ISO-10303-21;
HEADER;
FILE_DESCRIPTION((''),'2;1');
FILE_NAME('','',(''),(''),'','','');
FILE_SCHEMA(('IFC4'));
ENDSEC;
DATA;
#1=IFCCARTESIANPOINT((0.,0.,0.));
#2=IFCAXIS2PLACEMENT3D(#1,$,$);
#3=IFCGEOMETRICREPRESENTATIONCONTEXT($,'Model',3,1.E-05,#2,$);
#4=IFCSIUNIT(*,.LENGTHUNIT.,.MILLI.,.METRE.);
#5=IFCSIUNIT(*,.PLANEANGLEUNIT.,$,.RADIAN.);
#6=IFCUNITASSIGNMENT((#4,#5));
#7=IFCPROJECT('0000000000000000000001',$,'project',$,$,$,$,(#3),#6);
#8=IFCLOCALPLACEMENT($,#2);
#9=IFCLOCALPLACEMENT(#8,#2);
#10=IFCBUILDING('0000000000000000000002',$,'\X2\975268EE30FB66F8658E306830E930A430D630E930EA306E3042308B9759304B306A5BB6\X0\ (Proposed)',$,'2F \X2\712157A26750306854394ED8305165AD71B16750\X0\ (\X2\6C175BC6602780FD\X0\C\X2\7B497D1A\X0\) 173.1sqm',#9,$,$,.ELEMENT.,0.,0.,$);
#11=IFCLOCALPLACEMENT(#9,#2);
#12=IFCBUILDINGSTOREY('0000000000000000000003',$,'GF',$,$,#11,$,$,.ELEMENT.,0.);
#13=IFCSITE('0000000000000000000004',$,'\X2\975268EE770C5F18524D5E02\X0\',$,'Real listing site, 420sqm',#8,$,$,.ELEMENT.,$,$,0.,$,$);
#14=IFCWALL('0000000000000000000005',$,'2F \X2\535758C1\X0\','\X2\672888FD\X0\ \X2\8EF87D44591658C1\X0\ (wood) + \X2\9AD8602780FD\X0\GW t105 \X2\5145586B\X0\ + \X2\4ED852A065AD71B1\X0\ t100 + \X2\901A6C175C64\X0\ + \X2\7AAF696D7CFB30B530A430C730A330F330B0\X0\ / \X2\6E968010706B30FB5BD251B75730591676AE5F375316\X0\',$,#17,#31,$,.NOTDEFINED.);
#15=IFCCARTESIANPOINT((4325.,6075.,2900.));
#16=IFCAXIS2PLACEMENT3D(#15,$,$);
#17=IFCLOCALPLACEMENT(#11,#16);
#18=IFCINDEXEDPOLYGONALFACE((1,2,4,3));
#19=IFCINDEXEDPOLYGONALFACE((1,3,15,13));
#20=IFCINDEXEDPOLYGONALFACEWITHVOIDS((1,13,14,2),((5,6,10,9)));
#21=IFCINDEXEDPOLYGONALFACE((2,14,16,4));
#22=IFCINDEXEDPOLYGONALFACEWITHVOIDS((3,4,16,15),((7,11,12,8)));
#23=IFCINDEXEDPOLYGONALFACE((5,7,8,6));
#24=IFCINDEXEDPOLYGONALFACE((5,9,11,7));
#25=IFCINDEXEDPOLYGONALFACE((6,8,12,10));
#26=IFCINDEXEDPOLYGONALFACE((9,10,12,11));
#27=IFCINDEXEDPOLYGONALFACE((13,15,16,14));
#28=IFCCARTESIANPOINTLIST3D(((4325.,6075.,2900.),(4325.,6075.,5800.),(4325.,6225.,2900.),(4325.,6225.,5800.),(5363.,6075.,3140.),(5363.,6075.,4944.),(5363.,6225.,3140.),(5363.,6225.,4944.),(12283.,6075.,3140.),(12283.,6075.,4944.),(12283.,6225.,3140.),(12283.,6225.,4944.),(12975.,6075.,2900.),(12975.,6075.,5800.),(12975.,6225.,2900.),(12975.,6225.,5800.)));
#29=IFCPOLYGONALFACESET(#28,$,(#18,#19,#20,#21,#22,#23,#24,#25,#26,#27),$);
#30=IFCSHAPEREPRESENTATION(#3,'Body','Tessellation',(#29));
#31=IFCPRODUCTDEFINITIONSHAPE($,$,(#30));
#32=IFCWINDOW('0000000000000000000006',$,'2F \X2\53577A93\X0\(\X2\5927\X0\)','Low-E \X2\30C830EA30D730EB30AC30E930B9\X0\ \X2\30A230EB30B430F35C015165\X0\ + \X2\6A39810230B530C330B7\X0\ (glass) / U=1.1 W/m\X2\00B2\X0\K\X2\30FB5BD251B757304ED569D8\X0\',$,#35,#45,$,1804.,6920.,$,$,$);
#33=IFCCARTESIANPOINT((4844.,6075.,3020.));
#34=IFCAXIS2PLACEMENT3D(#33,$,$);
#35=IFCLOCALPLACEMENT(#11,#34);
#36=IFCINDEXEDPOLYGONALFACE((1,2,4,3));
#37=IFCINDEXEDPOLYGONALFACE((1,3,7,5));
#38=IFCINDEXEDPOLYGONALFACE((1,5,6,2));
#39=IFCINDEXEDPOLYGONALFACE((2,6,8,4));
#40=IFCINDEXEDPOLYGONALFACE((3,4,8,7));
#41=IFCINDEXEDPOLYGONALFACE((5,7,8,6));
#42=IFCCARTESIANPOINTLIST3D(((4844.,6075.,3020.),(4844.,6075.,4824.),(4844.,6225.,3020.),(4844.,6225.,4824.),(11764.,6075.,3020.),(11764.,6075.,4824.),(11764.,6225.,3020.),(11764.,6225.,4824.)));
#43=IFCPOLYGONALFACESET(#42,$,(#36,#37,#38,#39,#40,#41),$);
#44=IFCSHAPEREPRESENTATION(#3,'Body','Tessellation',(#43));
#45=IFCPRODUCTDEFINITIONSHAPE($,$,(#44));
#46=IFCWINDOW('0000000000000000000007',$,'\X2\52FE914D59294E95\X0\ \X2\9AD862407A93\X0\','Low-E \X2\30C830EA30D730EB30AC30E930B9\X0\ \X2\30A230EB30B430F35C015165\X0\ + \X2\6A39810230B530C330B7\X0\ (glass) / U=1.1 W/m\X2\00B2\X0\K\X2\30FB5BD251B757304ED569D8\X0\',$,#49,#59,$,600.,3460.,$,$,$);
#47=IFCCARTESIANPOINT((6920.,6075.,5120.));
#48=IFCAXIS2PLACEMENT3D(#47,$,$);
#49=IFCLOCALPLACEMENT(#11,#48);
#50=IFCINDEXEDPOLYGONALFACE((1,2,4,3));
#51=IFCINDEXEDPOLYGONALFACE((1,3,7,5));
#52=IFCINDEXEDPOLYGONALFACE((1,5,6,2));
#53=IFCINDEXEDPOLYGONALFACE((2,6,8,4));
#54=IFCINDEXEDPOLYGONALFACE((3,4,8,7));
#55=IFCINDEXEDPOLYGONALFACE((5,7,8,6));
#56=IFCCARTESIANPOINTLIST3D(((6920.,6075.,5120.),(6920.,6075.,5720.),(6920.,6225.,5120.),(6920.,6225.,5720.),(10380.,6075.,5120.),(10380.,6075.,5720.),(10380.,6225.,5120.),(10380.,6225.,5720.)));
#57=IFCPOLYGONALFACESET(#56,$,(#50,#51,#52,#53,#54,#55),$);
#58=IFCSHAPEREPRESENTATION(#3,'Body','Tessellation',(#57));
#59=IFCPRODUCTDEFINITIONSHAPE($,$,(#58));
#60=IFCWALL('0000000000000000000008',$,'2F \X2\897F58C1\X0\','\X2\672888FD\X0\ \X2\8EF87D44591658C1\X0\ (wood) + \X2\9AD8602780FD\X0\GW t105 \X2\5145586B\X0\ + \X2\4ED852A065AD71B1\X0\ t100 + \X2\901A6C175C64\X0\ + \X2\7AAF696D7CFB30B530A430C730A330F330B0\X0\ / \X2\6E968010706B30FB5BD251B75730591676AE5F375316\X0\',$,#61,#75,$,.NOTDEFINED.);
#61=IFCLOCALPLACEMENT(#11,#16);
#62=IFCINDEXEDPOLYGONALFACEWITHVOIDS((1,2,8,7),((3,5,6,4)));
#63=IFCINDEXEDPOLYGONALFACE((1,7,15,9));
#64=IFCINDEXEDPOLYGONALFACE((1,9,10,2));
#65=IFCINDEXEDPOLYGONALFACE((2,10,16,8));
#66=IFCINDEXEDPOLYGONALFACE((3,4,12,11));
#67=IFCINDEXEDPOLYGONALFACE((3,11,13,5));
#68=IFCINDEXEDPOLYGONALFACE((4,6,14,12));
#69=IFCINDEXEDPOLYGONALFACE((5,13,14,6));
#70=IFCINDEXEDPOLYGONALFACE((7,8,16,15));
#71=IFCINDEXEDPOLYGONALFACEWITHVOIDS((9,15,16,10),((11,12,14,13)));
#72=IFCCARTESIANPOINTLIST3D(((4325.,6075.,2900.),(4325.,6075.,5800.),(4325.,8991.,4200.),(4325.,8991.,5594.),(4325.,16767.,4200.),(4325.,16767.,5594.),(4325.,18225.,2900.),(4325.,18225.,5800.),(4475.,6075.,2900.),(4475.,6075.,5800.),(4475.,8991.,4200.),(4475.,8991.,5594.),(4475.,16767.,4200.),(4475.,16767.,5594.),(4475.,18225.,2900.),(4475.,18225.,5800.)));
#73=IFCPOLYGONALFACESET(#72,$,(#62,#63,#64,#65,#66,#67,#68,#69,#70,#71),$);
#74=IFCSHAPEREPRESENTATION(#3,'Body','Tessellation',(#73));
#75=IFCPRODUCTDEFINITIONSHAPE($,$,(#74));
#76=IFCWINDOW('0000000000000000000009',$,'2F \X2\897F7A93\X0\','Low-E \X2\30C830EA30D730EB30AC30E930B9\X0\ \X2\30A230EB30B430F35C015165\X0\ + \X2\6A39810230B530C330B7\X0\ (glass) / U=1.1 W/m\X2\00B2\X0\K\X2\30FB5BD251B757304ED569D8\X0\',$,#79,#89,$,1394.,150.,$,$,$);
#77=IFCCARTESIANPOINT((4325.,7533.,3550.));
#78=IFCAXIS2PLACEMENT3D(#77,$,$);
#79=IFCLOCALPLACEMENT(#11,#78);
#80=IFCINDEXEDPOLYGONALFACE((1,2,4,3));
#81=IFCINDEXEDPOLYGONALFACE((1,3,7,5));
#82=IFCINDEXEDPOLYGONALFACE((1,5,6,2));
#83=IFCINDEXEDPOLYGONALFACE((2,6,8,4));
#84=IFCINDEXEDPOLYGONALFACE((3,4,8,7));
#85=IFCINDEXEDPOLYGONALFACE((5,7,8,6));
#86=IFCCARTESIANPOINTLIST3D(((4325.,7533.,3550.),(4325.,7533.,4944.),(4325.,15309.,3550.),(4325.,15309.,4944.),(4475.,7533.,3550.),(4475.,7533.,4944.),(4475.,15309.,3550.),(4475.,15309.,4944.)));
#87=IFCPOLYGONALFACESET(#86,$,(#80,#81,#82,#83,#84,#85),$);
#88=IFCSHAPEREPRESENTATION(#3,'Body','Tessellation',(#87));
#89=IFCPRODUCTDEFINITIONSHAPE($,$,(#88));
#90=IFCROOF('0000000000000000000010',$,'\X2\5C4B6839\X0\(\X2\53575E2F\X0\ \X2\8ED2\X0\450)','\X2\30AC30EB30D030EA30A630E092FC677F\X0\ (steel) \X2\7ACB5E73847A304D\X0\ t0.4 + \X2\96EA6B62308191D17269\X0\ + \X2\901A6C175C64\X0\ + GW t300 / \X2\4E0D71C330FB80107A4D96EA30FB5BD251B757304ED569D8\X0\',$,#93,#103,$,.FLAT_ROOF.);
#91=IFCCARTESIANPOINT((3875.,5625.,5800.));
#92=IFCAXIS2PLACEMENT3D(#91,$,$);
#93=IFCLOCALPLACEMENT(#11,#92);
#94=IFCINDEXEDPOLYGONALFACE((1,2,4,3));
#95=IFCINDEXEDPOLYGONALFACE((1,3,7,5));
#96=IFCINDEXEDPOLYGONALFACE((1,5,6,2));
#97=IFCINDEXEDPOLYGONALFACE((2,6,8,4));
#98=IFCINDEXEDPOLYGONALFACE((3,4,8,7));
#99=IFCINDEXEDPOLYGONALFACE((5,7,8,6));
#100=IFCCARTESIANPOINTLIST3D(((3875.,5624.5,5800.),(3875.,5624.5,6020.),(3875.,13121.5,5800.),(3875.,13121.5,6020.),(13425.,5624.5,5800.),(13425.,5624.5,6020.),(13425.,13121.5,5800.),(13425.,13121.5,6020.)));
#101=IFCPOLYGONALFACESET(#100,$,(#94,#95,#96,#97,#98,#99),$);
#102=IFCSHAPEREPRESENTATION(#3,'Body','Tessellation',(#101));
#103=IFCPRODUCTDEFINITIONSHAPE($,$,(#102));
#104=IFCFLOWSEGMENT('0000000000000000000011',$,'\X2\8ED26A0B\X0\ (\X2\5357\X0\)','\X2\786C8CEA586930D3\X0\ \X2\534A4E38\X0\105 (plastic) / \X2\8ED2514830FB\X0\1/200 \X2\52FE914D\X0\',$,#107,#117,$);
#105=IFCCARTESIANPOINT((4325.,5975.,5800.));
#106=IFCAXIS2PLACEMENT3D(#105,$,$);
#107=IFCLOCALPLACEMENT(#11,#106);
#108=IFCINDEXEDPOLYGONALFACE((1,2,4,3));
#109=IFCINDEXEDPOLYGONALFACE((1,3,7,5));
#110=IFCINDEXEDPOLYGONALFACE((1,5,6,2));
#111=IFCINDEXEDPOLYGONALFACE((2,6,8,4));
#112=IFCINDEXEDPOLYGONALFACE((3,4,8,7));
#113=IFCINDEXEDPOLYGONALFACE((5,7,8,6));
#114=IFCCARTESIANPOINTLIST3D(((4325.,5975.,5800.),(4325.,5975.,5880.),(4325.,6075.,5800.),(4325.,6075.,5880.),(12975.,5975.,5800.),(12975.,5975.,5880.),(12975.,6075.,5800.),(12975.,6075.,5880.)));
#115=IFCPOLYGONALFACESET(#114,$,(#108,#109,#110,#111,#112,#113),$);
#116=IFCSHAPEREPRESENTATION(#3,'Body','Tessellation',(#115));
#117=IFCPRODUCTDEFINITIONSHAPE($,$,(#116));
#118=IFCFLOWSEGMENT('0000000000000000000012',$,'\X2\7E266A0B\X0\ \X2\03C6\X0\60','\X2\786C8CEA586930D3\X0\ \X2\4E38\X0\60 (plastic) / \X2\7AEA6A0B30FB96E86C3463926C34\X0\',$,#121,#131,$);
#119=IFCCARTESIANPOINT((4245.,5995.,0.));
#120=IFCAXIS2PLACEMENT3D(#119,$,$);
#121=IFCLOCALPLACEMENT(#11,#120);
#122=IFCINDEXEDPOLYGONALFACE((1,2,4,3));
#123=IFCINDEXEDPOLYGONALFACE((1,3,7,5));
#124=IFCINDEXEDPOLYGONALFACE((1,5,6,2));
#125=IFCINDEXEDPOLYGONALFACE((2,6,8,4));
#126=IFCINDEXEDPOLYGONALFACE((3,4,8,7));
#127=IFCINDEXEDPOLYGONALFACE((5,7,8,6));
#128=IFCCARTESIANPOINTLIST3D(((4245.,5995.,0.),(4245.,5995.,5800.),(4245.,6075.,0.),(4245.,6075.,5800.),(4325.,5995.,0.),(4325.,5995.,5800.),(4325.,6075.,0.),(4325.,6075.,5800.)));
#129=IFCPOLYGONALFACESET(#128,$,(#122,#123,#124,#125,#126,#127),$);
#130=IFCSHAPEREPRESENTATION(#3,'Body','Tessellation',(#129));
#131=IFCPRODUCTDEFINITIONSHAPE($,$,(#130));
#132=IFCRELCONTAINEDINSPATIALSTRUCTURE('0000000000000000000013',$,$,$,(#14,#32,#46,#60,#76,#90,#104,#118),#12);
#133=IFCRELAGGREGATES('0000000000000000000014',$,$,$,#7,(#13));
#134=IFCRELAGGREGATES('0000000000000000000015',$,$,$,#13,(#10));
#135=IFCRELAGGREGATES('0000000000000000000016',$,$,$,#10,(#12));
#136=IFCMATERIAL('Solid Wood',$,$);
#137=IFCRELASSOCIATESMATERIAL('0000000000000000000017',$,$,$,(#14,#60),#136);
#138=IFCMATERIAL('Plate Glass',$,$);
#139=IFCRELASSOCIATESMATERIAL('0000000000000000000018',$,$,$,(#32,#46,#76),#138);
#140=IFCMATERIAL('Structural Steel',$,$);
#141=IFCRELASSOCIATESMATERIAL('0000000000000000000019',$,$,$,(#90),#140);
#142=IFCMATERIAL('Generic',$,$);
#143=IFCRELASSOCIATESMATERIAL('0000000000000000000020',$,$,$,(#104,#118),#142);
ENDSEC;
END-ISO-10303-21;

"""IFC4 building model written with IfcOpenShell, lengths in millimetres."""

from ifc_helpers import new_model, si_unit, frame, frame_2d, origin, place, context, project, spatial, rectangle, extrude, material, element, fill, save


model = new_model("IFC4")

# Units and contexts
model_context = context("Model", 3, precision=1e-05, world=origin())
ifc_project = project(units=[si_unit("LENGTHUNIT", "METRE", prefix="MILLI"), si_unit("PLANEANGLEUNIT", "RADIAN")], contexts=[model_context])

# Site, building, storey
site_placement = place(None, origin())
site = spatial("IfcSite", under=ifc_project, at=site_placement, Name="青森県弘前市", ObjectType="Real listing site, 420sqm", CompositionType="ELEMENT", RefElevation=0.0)
building_placement = place(site_placement, origin())
building = spatial("IfcBuilding", under=site, at=building_placement, Name="青森・書斎とライブラリのある静かな家 (Proposed)", ObjectType="2F 無垢材と吹付け断熱材 (気密性能C等級) 173.1sqm", CompositionType="ELEMENT", ElevationOfRefHeight=0.0, ElevationOfTerrain=0.0)
storey_placement = place(building_placement, origin())
storey = spatial("IfcBuildingStorey", under=building, at=storey_placement, Name="GF", CompositionType="ELEMENT", Elevation=0.0)

# Shared definitions
ifc_material_1 = material(Name="Solid Wood")

# Shared definitions
ifc_material_2 = material(Name="Plate Glass")

# Wall, openings, windows
wall_1_placement = place(storey_placement, frame((4325.0, 6075.0, 2900.0)))
wall_1 = element("IfcWall", 1, at=wall_1_placement, inside=storey, material=ifc_material_1, Name="2F 南壁", Description="木製 軸組外壁 (wood) + 高性能GW t105 充填 + 付加断熱 t100 + 通気層 + 窯業系サイディング / 準耐火・寒冷地外皮強化", PredefinedType="NOTDEFINED", context=model_context, shape_type="SweptSolid", body=[
    extrude(rectangle(XDim=8650.0, YDim=150.0, at=frame_2d((4325.0, 75.0))), frame((4325.0, 6075.0, 2900.0)), (0.0, 0.0, 1.0), 2900.0),
])
opening_1_placement = place(storey_placement, frame((4844.0, 6075.0, 3020.0)))
opening_1 = element("IfcOpeningElement", 2, at=opening_1_placement, cuts=wall_1, PredefinedType="NOTDEFINED", context=model_context, shape_type="SweptSolid", body=[
    extrude(rectangle(XDim=6920.0, YDim=150.0, at=frame_2d((3460.0, 75.0))), frame((4844.0, 6075.0, 3020.0)), (0.0, 0.0, 1.0), 1804.0),
])
opening_2_placement = place(storey_placement, frame((6920.0, 6075.0, 5120.0)))
opening_2 = element("IfcOpeningElement", 3, at=opening_2_placement, cuts=wall_1, PredefinedType="NOTDEFINED", context=model_context, shape_type="SweptSolid", body=[
    extrude(rectangle(XDim=3460.0, YDim=150.0, at=frame_2d((1730.0, 75.0))), frame((6920.0, 6075.0, 5120.0)), (0.0, 0.0, 1.0), 600.0),
])
window_1_placement = place(storey_placement, frame((4844.0, 6075.0, 3020.0)))
window_1 = element("IfcWindow", 4, at=window_1_placement, inside=storey, material=ifc_material_2, Name="2F 南窓(大)", Description="Low-E トリプルガラス アルゴン封入 + 樹脂サッシ (glass) / U=1.1 W/m²K・寒冷地仕様", OverallHeight=1804.0, OverallWidth=6920.0, context=model_context, shape_type="SweptSolid", body=[
    extrude(rectangle(XDim=6920.0, YDim=150.0, at=frame_2d((3460.0, 75.0))), frame((4844.0, 6075.0, 3020.0)), (0.0, 0.0, 1.0), 1804.0),
])
fill(opening_1, window_1)
window_2_placement = place(storey_placement, frame((6920.0, 6075.0, 5120.0)))
window_2 = element("IfcWindow", 5, at=window_2_placement, inside=storey, material=ifc_material_2, Name="勾配天井 高所窓", Description="Low-E トリプルガラス アルゴン封入 + 樹脂サッシ (glass) / U=1.1 W/m²K・寒冷地仕様", OverallHeight=600.0, OverallWidth=3460.0, context=model_context, shape_type="SweptSolid", body=[
    extrude(rectangle(XDim=3460.0, YDim=150.0, at=frame_2d((1730.0, 75.0))), frame((6920.0, 6075.0, 5120.0)), (0.0, 0.0, 1.0), 600.0),
])
fill(opening_2, window_2)

# Wall, opening, window
wall_2_placement = place(storey_placement, frame((4325.0, 6075.0, 2900.0)))
wall_2 = element("IfcWall", 6, at=wall_2_placement, inside=storey, material=ifc_material_1, Name="2F 西壁", Description="木製 軸組外壁 (wood) + 高性能GW t105 充填 + 付加断熱 t100 + 通気層 + 窯業系サイディング / 準耐火・寒冷地外皮強化", PredefinedType="NOTDEFINED", context=model_context, shape_type="SweptSolid", body=[
    extrude(rectangle(XDim=150.0, YDim=12150.0, at=frame_2d((75.0, 6075.0))), frame((4325.0, 6075.0, 2900.0)), (0.0, 0.0, 1.0), 2900.0),
])
opening_3_placement = place(storey_placement, frame((4325.0, 7533.0, 3550.0)))
opening_3 = element("IfcOpeningElement", 7, at=opening_3_placement, cuts=wall_2, PredefinedType="NOTDEFINED", context=model_context, shape_type="SweptSolid", body=[
    extrude(rectangle(XDim=150.0, YDim=7776.0, at=frame_2d((75.0, 3888.0))), frame((4325.0, 7533.0, 3550.0)), (0.0, 0.0, 1.0), 1394.0),
])
window_3_placement = place(storey_placement, frame((4325.0, 7533.0, 3550.0)))
window_3 = element("IfcWindow", 8, at=window_3_placement, inside=storey, material=ifc_material_2, Name="2F 西窓", Description="Low-E トリプルガラス アルゴン封入 + 樹脂サッシ (glass) / U=1.1 W/m²K・寒冷地仕様", OverallHeight=1394.0, OverallWidth=150.0, context=model_context, shape_type="SweptSolid", body=[
    extrude(rectangle(XDim=150.0, YDim=7776.0, at=frame_2d((75.0, 3888.0))), frame((4325.0, 7533.0, 3550.0)), (0.0, 0.0, 1.0), 1394.0),
])
fill(opening_3, window_3)

# Roof
ifc_material_3 = material(Name="Structural Steel")
for number, where, name in (
    (9, (3875.0, 5625.0, 5800.0), "屋根(南帯 軒450)"),
):
    element("IfcRoof", number, at=place(storey_placement, frame(where)), inside=storey, material=ifc_material_3, Name=name, Description="ガルバリウム鋼板 (steel) 立平葺き t0.4 + 雪止め金物 + 通気層 + GW t300 / 不燃・耐積雪・寒冷地仕様", PredefinedType="FLAT_ROOF", context=model_context, shape_type="SweptSolid", body=[
        extrude(rectangle(XDim=9550.0, YDim=7497.0, at=frame_2d((4775.0, 3748.0))), frame((3875.0, 5625.0, 5800.0)), (0.0, 0.0, 1.0), 220.0),
    ])

# Flow segments
ifc_material_4 = material(Name="Generic")
flow_segment_1_placement = place(storey_placement, frame((4325.0, 5975.0, 5800.0)))
element("IfcFlowSegment", 10, at=flow_segment_1_placement, inside=storey, material=ifc_material_4, Name="軒樋 (南)", Description="硬質塩ビ 半丸105 (plastic) / 軒先・1/200 勾配", context=model_context, shape_type="SweptSolid", body=[
    extrude(rectangle(XDim=8650.0, YDim=100.0, at=frame_2d((4325.0, 50.0))), frame((4325.0, 5975.0, 5800.0)), (0.0, 0.0, 1.0), 80.0),
])
flow_segment_2_placement = place(storey_placement, frame((4245.0, 5995.0, 0.0)))
element("IfcFlowSegment", 11, at=flow_segment_2_placement, inside=storey, material=ifc_material_4, Name="縦樋 φ60", Description="硬質塩ビ 丸60 (plastic) / 竪樋・雨水排水", context=model_context, shape_type="SweptSolid", body=[
    extrude(rectangle(XDim=80.0, YDim=80.0, at=frame_2d((40.0, 40.0))), frame((4245.0, 5995.0, 0.0)), (0.0, 0.0, 1.0), 5800.0),
])

save(model, "model.ifc")
